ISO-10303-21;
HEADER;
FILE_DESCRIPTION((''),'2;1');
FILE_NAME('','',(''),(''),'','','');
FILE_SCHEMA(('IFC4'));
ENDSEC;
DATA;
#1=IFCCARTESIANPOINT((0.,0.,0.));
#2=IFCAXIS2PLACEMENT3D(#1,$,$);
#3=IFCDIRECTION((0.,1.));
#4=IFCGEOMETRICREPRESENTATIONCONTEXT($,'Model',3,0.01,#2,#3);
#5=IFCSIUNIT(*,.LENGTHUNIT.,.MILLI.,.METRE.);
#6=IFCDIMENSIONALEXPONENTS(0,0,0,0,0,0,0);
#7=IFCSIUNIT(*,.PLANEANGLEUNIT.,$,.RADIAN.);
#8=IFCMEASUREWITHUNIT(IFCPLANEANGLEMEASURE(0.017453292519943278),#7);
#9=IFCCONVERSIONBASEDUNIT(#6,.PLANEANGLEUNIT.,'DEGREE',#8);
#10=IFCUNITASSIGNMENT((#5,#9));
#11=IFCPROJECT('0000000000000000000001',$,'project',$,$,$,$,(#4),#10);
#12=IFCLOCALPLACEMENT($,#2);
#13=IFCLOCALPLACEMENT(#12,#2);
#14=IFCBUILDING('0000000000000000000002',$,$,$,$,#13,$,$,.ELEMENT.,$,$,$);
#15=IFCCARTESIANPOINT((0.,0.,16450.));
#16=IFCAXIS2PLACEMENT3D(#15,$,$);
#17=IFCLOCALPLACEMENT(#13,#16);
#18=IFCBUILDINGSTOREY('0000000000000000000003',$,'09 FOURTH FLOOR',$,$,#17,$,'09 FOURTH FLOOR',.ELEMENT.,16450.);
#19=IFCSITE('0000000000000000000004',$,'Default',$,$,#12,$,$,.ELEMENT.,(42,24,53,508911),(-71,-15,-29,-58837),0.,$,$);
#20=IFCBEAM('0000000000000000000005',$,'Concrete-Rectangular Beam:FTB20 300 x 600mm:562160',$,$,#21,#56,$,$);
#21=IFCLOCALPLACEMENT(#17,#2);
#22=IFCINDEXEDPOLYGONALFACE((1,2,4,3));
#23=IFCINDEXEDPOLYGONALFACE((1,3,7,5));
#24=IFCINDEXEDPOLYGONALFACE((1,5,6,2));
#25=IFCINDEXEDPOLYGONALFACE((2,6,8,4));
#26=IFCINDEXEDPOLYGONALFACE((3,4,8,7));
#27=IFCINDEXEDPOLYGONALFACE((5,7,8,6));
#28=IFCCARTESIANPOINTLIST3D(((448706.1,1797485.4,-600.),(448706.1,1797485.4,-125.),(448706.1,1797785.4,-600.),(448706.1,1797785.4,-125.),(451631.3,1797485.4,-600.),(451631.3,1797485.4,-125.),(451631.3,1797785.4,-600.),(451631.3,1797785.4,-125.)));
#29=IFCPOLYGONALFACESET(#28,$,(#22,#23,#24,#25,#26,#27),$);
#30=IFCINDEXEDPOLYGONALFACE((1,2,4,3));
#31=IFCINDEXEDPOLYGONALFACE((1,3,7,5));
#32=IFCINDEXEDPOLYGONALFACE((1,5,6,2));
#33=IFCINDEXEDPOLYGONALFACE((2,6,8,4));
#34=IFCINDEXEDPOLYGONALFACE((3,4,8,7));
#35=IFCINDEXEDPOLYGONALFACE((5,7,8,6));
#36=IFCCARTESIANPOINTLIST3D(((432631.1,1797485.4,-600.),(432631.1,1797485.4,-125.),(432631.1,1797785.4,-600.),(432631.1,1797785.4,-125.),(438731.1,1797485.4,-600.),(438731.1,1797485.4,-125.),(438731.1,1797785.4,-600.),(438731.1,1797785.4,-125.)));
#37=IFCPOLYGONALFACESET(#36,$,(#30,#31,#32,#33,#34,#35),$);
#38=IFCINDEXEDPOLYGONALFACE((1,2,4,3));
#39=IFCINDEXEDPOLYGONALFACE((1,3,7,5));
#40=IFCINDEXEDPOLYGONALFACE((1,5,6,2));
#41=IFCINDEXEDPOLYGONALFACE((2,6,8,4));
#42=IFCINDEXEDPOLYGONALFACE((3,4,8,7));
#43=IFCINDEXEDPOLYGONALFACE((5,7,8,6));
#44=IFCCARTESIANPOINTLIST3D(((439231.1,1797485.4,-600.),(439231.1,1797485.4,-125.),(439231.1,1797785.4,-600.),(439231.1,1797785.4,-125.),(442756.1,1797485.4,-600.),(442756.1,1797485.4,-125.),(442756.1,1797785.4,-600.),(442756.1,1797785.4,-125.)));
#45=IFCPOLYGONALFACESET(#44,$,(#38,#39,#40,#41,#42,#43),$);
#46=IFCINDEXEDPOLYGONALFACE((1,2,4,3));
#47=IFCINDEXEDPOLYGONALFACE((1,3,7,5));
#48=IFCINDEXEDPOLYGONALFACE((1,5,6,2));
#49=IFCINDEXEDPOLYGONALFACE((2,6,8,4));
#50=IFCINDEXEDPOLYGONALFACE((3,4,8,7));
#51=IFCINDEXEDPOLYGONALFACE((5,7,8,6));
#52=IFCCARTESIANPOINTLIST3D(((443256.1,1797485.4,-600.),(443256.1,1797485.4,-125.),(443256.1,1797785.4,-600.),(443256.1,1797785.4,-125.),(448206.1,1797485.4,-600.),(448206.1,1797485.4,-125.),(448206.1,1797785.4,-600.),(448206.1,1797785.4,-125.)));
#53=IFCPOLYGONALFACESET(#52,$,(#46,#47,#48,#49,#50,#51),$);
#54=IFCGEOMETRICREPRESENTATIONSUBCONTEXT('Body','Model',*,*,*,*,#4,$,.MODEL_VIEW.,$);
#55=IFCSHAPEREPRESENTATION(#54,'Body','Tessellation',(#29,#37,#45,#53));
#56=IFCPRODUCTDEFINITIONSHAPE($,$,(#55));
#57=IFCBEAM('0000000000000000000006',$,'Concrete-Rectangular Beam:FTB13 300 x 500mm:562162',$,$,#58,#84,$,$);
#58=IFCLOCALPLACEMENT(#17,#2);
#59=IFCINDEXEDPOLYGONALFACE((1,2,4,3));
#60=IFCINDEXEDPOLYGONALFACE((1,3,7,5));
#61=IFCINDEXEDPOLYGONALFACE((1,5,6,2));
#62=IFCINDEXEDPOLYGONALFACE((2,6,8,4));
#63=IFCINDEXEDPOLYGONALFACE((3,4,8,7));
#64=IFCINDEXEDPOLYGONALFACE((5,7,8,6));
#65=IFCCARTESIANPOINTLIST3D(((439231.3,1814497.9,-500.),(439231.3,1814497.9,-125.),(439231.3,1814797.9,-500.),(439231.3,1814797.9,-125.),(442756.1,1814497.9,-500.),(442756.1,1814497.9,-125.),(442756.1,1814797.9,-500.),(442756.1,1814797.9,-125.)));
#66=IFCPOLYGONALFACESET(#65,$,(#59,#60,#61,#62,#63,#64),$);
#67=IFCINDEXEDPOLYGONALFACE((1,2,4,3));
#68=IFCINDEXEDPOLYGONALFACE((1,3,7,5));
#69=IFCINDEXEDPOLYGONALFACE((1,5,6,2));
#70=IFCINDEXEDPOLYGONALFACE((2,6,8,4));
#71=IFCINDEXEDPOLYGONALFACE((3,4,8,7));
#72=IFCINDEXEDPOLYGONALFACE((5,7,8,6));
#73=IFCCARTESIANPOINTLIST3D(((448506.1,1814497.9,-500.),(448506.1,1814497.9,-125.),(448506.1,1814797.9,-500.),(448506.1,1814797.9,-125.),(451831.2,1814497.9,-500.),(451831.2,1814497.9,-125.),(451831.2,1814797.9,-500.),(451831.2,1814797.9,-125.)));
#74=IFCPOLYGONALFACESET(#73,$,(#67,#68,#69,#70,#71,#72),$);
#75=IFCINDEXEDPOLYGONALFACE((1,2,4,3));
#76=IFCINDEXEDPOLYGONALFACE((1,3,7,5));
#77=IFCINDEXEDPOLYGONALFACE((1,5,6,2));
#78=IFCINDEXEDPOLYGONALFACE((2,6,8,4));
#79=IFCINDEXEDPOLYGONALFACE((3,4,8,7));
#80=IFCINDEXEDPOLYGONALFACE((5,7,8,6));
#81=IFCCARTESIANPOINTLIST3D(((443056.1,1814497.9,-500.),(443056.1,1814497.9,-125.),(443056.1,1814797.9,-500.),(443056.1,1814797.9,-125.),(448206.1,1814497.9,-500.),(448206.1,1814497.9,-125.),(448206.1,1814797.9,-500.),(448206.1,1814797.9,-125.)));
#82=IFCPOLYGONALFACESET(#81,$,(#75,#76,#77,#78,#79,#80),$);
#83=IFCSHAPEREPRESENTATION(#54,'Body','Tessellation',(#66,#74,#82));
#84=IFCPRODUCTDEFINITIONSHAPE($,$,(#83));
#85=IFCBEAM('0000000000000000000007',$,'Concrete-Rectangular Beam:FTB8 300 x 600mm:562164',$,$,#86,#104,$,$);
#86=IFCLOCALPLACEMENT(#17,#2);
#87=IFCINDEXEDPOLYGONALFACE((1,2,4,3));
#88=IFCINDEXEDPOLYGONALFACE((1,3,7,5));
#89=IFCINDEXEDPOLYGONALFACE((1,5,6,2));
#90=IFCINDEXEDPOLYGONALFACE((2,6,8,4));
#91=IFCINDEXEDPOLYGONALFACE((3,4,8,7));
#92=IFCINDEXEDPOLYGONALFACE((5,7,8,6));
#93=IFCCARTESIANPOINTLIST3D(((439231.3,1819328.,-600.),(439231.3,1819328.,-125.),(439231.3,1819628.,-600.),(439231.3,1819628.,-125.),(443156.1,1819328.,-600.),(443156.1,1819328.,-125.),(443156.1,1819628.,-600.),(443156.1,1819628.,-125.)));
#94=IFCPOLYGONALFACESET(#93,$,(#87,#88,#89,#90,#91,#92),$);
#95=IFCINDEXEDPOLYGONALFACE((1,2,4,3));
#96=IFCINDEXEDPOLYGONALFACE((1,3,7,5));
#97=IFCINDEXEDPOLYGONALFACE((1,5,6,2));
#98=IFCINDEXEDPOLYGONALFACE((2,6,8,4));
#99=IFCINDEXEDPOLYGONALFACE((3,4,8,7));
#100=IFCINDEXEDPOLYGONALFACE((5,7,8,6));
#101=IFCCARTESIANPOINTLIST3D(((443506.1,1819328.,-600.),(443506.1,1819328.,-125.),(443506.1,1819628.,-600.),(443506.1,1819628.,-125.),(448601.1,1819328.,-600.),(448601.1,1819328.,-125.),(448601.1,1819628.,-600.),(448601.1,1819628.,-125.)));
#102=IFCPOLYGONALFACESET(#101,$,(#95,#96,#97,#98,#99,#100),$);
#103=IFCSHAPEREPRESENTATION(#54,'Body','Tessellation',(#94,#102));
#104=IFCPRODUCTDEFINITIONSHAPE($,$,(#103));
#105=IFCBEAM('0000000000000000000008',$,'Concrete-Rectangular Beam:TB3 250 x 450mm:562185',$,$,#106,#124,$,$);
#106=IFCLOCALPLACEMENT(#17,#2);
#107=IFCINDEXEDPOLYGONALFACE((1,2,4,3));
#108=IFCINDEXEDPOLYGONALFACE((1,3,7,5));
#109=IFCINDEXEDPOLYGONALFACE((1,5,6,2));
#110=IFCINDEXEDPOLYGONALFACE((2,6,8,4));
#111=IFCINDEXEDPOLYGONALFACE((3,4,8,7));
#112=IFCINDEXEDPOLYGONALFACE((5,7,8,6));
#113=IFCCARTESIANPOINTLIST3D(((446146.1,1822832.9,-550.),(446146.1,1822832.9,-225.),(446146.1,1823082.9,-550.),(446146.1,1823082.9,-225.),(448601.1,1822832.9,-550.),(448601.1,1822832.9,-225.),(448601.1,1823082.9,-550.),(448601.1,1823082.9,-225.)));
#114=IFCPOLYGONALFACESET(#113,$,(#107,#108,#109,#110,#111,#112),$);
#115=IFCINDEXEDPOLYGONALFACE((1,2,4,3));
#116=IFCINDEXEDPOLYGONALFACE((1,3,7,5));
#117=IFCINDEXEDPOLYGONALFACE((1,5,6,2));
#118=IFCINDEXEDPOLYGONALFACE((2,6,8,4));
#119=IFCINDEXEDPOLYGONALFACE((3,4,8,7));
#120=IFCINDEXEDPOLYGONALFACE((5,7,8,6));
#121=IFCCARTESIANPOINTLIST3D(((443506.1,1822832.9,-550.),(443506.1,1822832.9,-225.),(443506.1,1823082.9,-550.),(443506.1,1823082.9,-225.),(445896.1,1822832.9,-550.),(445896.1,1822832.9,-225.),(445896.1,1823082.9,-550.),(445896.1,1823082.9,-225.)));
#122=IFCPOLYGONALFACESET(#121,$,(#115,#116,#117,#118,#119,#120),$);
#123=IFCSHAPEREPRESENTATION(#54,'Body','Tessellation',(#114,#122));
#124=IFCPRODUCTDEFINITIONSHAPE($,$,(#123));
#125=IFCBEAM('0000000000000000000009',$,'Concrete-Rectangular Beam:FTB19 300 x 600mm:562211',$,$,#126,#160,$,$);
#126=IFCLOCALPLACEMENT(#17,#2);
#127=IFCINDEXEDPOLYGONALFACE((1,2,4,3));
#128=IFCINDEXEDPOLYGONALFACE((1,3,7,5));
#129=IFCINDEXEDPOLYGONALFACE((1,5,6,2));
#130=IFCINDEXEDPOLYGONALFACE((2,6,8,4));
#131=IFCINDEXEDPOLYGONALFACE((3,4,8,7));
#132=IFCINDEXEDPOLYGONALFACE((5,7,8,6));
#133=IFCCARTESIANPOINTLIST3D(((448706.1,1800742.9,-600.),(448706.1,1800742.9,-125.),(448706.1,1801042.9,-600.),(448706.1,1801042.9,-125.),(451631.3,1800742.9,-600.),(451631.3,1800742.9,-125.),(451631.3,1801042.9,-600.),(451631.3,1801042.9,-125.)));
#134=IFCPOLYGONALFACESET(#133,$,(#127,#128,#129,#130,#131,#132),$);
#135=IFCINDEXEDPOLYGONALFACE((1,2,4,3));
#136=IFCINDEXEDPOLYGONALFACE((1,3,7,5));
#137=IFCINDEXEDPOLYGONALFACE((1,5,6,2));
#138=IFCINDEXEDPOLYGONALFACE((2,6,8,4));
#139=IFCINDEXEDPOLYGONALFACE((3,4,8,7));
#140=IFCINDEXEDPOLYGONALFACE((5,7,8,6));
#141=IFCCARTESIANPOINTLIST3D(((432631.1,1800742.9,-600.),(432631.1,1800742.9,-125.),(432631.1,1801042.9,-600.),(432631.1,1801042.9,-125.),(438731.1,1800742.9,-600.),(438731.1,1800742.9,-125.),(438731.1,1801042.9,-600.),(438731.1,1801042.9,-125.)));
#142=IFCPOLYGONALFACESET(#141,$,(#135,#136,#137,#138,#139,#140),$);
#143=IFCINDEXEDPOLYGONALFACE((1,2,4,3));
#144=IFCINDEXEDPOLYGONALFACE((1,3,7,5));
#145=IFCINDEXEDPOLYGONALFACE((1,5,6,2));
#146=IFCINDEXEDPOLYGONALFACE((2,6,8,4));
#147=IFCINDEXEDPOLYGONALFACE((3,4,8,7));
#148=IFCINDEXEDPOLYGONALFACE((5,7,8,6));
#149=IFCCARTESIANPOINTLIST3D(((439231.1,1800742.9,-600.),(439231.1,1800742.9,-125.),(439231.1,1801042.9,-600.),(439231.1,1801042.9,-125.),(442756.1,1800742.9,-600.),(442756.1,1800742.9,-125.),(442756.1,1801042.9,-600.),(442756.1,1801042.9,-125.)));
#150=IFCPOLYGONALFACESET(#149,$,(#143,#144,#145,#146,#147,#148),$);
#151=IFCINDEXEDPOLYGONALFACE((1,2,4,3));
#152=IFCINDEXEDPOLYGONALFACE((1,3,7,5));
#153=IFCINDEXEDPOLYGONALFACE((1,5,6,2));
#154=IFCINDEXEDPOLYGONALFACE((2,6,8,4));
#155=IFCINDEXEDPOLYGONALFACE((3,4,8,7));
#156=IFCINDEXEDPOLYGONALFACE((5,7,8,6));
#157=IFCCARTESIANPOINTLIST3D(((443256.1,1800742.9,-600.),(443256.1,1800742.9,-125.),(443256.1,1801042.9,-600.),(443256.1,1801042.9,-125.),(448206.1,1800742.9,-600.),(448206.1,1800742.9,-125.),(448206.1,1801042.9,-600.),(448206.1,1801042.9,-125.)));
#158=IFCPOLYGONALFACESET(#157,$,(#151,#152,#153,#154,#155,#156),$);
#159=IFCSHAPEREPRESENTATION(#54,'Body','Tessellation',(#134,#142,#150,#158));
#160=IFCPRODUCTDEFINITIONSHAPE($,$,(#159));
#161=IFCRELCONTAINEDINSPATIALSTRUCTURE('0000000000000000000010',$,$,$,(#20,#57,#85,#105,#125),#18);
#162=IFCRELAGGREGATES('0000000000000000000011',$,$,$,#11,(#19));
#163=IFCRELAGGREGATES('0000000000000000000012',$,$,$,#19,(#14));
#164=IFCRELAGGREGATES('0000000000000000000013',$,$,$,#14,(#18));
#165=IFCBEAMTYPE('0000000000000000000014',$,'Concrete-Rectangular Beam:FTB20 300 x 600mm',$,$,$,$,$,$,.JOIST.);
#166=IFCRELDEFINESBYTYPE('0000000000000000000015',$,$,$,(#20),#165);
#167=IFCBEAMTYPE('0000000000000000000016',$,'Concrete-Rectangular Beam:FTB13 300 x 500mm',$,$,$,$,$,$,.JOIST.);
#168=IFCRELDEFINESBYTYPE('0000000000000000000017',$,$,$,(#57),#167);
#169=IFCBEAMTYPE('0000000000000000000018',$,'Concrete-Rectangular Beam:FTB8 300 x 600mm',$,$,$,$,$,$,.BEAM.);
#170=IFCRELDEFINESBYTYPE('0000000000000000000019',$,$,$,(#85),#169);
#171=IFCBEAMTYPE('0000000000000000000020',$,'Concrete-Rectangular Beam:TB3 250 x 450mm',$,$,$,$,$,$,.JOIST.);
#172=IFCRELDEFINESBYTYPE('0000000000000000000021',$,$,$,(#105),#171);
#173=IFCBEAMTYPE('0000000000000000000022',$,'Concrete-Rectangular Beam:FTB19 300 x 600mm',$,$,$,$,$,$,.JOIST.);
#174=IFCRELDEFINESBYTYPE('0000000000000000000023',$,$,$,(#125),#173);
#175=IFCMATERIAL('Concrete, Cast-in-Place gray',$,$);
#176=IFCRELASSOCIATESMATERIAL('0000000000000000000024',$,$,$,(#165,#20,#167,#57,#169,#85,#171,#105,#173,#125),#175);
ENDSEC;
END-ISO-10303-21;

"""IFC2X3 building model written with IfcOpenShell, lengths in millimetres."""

from ifc_helpers import new_model, entity, si_unit, converted_unit, direction, frame, frame_2d, origin, origin_2d_with_axis, place, context, subcontext, project, spatial, rectangle, extrude, source, transform, mapped, material, type_object, type_shapes, element, save


model = new_model("IFC2X3")

# Units and contexts
model_context = context("Model", 3, precision=0.01, world=origin(), true_north=direction((0.0, 1.0)))
body_context = subcontext(model_context, "Body", "Model", "MODEL_VIEW")
ifc_project = project(units=[si_unit("LENGTHUNIT", "METRE", prefix="MILLI"), converted_unit("PLANEANGLEUNIT", "DEGREE", entity("IfcPlaneAngleMeasure", 0.017453292519943278), si_unit("PLANEANGLEUNIT", "RADIAN"), dimensions=[0, 0, 0, 0, 0, 0, 0])], contexts=[model_context])

# Site, building, storey
site_placement = place(None, origin())
site = spatial("IfcSite", under=ifc_project, at=site_placement, Name="Default", CompositionType="ELEMENT", RefLatitude=(42, 24, 53, 508911), RefLongitude=(-71, -15, -29, -58837), RefElevation=0.0)
building_placement = place(site_placement, origin())
building = spatial("IfcBuilding", under=site, at=building_placement, CompositionType="ELEMENT")
storey_placement = place(building_placement, frame((0.0, 0.0, 16450.0)))
storey = spatial("IfcBuildingStorey", under=building, at=storey_placement, Name="09 FOURTH FLOOR", LongName="09 FOURTH FLOOR", CompositionType="ELEMENT", Elevation=16450.0)

# Shared definitions
ifc_material = material(Name="Concrete, Cast-in-Place gray")

# Beams
beam_type_1 = type_object("IfcBeamType", Name="Concrete-Rectangular Beam:FTB20 300 x 600mm", PredefinedType="JOIST", material=ifc_material)
shared_shape_1 = source(origin(), body_context, "Body", "SweptSolid", [
    extrude(rectangle(XDim=475.0, YDim=300.0, at=frame_2d((0.0, 0.0), x_axis=(1.0, 0.0))), frame((448706.1, 1797635.4, 16087.5), z_axis=(1.0, 0.0, 0.0), x_axis=(0.0, 0.0, -1.0)), (0.0, 0.0, 1.0), 2925.1),
    extrude(rectangle(XDim=475.0, YDim=300.0, at=frame_2d((0.0, 0.0), x_axis=(1.0, 0.0))), frame((432631.1, 1797635.4, 16087.5), z_axis=(1.0, 0.0, 0.0), x_axis=(0.0, 0.0, -1.0)), (0.0, 0.0, 1.0), 6100.0),
    extrude(rectangle(XDim=475.0, YDim=300.0, at=frame_2d((0.0, 0.0), x_axis=(1.0, 0.0))), frame((439231.1, 1797635.4, 16087.5), z_axis=(1.0, 0.0, 0.0), x_axis=(0.0, 0.0, -1.0)), (0.0, 0.0, 1.0), 3525.0),
    extrude(rectangle(XDim=475.0, YDim=300.0, at=frame_2d((0.0, 0.0), x_axis=(1.0, 0.0))), frame((443256.1, 1797635.4, 16087.5), z_axis=(1.0, 0.0, 0.0), x_axis=(0.0, 0.0, -1.0)), (0.0, 0.0, 1.0), 4950.0),
])
type_shapes(beam_type_1, [shared_shape_1])
beam_1_placement = place(storey_placement, frame((0.0, 0.0, -16450.0)))
element("IfcBeam", 1, at=beam_1_placement, inside=storey, type_object=beam_type_1, material=ifc_material, Name="Concrete-Rectangular Beam:FTB20 300 x 600mm:562160", context=body_context, shape_type="MappedRepresentation", body=[
    mapped(shared_shape_1, transform((0.0, 0.0, 0.0), scale=1.0)),
])
beam_type_2 = type_object("IfcBeamType", Name="Concrete-Rectangular Beam:FTB13 300 x 500mm", PredefinedType="JOIST", material=ifc_material)
shared_shape_2 = source(origin(), body_context, "Body", "SweptSolid", [
    extrude(rectangle(XDim=375.0, YDim=300.0, at=origin_2d_with_axis()), frame((439231.3, 1814647.9, 16137.5), z_axis=(1.0, 0.0, 0.0), x_axis=(0.0, 0.0, -1.0)), (0.0, 0.0, 1.0), 3524.9),
    extrude(rectangle(XDim=375.0, YDim=300.0, at=origin_2d_with_axis()), frame((448506.1, 1814647.9, 16137.5), z_axis=(1.0, 0.0, 0.0), x_axis=(0.0, 0.0, -1.0)), (0.0, 0.0, 1.0), 3325.1),
    extrude(rectangle(XDim=375.0, YDim=300.0, at=origin_2d_with_axis()), frame((443056.1, 1814647.9, 16137.5), z_axis=(1.0, 0.0, 0.0), x_axis=(0.0, 0.0, -1.0)), (0.0, 0.0, 1.0), 5150.0),
])
type_shapes(beam_type_2, [shared_shape_2])
beam_2_placement = place(storey_placement, frame((0.0, 0.0, -16450.0)))
element("IfcBeam", 2, at=beam_2_placement, inside=storey, type_object=beam_type_2, material=ifc_material, Name="Concrete-Rectangular Beam:FTB13 300 x 500mm:562162", context=body_context, shape_type="MappedRepresentation", body=[
    mapped(shared_shape_2, transform((0.0, 0.0, 0.0), scale=1.0)),
])
beam_type_3 = type_object("IfcBeamType", Name="Concrete-Rectangular Beam:FTB8 300 x 600mm", PredefinedType="BEAM", material=ifc_material)
shared_shape_3 = source(origin(), body_context, "Body", "SweptSolid", [
    extrude(rectangle(XDim=475.0, YDim=300.0, at=frame_2d((0.0, 0.0), x_axis=(1.0, 0.0))), frame((439231.3, 1819478.0, 16087.5), z_axis=(1.0, 0.0, 0.0), x_axis=(0.0, 0.0, -1.0)), (0.0, 0.0, 1.0), 3924.8),
    extrude(rectangle(XDim=475.0, YDim=300.0, at=frame_2d((0.0, 0.0), x_axis=(1.0, 0.0))), frame((443506.1, 1819478.0, 16087.5), z_axis=(1.0, 0.0, 0.0), x_axis=(0.0, 0.0, -1.0)), (0.0, 0.0, 1.0), 5095.0),
])
type_shapes(beam_type_3, [shared_shape_3])
beam_3_placement = place(storey_placement, frame((0.0, 0.0, -16450.0)))
element("IfcBeam", 3, at=beam_3_placement, inside=storey, type_object=beam_type_3, material=ifc_material, Name="Concrete-Rectangular Beam:FTB8 300 x 600mm:562164", context=body_context, shape_type="MappedRepresentation", body=[
    mapped(shared_shape_3, transform((0.0, 0.0, 0.0), scale=1.0)),
])
beam_type_4 = type_object("IfcBeamType", Name="Concrete-Rectangular Beam:TB3 250 x 450mm", PredefinedType="JOIST", material=ifc_material)
shared_shape_4 = source(origin(), body_context, "Body", "SweptSolid", [
    extrude(rectangle(XDim=325.0, YDim=250.0, at=frame_2d((0.0, 0.0), x_axis=(1.0, 0.0))), frame((446146.1, 1822957.9, 16062.5), z_axis=(1.0, 0.0, 0.0), x_axis=(0.0, 0.0, -1.0)), (0.0, 0.0, 1.0), 2455.0),
    extrude(rectangle(XDim=325.0, YDim=250.0, at=frame_2d((0.0, 0.0), x_axis=(1.0, 0.0))), frame((443506.1, 1822957.9, 16062.5), z_axis=(1.0, 0.0, 0.0), x_axis=(0.0, 0.0, -1.0)), (0.0, 0.0, 1.0), 2390.0),
])
type_shapes(beam_type_4, [shared_shape_4])
beam_4_placement = place(storey_placement, frame((0.0, 0.0, -16450.0)))
element("IfcBeam", 4, at=beam_4_placement, inside=storey, type_object=beam_type_4, material=ifc_material, Name="Concrete-Rectangular Beam:TB3 250 x 450mm:562185", context=body_context, shape_type="MappedRepresentation", body=[
    mapped(shared_shape_4, transform((0.0, 0.0, 0.0), scale=1.0)),
])
beam_type_5 = type_object("IfcBeamType", Name="Concrete-Rectangular Beam:FTB19 300 x 600mm", PredefinedType="JOIST", material=ifc_material)
shared_shape_5 = source(origin(), body_context, "Body", "SweptSolid", [
    extrude(rectangle(XDim=475.0, YDim=300.0, at=frame_2d((0.0, 0.0), x_axis=(1.0, 0.0))), frame((448706.1, 1800892.9, 16087.5), z_axis=(1.0, 0.0, 0.0), x_axis=(0.0, 0.0, -1.0)), (0.0, 0.0, 1.0), 2925.1),
    extrude(rectangle(XDim=475.0, YDim=300.0, at=frame_2d((0.0, 0.0), x_axis=(1.0, 0.0))), frame((432631.1, 1800892.9, 16087.5), z_axis=(1.0, 0.0, 0.0), x_axis=(0.0, 0.0, -1.0)), (0.0, 0.0, 1.0), 6100.0),
    extrude(rectangle(XDim=475.0, YDim=300.0, at=frame_2d((0.0, 0.0), x_axis=(1.0, 0.0))), frame((439231.1, 1800892.9, 16087.5), z_axis=(1.0, 0.0, 0.0), x_axis=(0.0, 0.0, -1.0)), (0.0, 0.0, 1.0), 3525.0),
    extrude(rectangle(XDim=475.0, YDim=300.0, at=frame_2d((0.0, 0.0), x_axis=(1.0, 0.0))), frame((443256.1, 1800892.9, 16087.5), z_axis=(1.0, 0.0, 0.0), x_axis=(0.0, 0.0, -1.0)), (0.0, 0.0, 1.0), 4950.0),
])
type_shapes(beam_type_5, [shared_shape_5])
beam_5_placement = place(storey_placement, frame((0.0, 0.0, -16450.0)))
element("IfcBeam", 5, at=beam_5_placement, inside=storey, type_object=beam_type_5, material=ifc_material, Name="Concrete-Rectangular Beam:FTB19 300 x 600mm:562211", context=body_context, shape_type="MappedRepresentation", body=[
    mapped(shared_shape_5, transform((0.0, 0.0, 0.0), scale=1.0)),
])

save(model, "model.ifc")
